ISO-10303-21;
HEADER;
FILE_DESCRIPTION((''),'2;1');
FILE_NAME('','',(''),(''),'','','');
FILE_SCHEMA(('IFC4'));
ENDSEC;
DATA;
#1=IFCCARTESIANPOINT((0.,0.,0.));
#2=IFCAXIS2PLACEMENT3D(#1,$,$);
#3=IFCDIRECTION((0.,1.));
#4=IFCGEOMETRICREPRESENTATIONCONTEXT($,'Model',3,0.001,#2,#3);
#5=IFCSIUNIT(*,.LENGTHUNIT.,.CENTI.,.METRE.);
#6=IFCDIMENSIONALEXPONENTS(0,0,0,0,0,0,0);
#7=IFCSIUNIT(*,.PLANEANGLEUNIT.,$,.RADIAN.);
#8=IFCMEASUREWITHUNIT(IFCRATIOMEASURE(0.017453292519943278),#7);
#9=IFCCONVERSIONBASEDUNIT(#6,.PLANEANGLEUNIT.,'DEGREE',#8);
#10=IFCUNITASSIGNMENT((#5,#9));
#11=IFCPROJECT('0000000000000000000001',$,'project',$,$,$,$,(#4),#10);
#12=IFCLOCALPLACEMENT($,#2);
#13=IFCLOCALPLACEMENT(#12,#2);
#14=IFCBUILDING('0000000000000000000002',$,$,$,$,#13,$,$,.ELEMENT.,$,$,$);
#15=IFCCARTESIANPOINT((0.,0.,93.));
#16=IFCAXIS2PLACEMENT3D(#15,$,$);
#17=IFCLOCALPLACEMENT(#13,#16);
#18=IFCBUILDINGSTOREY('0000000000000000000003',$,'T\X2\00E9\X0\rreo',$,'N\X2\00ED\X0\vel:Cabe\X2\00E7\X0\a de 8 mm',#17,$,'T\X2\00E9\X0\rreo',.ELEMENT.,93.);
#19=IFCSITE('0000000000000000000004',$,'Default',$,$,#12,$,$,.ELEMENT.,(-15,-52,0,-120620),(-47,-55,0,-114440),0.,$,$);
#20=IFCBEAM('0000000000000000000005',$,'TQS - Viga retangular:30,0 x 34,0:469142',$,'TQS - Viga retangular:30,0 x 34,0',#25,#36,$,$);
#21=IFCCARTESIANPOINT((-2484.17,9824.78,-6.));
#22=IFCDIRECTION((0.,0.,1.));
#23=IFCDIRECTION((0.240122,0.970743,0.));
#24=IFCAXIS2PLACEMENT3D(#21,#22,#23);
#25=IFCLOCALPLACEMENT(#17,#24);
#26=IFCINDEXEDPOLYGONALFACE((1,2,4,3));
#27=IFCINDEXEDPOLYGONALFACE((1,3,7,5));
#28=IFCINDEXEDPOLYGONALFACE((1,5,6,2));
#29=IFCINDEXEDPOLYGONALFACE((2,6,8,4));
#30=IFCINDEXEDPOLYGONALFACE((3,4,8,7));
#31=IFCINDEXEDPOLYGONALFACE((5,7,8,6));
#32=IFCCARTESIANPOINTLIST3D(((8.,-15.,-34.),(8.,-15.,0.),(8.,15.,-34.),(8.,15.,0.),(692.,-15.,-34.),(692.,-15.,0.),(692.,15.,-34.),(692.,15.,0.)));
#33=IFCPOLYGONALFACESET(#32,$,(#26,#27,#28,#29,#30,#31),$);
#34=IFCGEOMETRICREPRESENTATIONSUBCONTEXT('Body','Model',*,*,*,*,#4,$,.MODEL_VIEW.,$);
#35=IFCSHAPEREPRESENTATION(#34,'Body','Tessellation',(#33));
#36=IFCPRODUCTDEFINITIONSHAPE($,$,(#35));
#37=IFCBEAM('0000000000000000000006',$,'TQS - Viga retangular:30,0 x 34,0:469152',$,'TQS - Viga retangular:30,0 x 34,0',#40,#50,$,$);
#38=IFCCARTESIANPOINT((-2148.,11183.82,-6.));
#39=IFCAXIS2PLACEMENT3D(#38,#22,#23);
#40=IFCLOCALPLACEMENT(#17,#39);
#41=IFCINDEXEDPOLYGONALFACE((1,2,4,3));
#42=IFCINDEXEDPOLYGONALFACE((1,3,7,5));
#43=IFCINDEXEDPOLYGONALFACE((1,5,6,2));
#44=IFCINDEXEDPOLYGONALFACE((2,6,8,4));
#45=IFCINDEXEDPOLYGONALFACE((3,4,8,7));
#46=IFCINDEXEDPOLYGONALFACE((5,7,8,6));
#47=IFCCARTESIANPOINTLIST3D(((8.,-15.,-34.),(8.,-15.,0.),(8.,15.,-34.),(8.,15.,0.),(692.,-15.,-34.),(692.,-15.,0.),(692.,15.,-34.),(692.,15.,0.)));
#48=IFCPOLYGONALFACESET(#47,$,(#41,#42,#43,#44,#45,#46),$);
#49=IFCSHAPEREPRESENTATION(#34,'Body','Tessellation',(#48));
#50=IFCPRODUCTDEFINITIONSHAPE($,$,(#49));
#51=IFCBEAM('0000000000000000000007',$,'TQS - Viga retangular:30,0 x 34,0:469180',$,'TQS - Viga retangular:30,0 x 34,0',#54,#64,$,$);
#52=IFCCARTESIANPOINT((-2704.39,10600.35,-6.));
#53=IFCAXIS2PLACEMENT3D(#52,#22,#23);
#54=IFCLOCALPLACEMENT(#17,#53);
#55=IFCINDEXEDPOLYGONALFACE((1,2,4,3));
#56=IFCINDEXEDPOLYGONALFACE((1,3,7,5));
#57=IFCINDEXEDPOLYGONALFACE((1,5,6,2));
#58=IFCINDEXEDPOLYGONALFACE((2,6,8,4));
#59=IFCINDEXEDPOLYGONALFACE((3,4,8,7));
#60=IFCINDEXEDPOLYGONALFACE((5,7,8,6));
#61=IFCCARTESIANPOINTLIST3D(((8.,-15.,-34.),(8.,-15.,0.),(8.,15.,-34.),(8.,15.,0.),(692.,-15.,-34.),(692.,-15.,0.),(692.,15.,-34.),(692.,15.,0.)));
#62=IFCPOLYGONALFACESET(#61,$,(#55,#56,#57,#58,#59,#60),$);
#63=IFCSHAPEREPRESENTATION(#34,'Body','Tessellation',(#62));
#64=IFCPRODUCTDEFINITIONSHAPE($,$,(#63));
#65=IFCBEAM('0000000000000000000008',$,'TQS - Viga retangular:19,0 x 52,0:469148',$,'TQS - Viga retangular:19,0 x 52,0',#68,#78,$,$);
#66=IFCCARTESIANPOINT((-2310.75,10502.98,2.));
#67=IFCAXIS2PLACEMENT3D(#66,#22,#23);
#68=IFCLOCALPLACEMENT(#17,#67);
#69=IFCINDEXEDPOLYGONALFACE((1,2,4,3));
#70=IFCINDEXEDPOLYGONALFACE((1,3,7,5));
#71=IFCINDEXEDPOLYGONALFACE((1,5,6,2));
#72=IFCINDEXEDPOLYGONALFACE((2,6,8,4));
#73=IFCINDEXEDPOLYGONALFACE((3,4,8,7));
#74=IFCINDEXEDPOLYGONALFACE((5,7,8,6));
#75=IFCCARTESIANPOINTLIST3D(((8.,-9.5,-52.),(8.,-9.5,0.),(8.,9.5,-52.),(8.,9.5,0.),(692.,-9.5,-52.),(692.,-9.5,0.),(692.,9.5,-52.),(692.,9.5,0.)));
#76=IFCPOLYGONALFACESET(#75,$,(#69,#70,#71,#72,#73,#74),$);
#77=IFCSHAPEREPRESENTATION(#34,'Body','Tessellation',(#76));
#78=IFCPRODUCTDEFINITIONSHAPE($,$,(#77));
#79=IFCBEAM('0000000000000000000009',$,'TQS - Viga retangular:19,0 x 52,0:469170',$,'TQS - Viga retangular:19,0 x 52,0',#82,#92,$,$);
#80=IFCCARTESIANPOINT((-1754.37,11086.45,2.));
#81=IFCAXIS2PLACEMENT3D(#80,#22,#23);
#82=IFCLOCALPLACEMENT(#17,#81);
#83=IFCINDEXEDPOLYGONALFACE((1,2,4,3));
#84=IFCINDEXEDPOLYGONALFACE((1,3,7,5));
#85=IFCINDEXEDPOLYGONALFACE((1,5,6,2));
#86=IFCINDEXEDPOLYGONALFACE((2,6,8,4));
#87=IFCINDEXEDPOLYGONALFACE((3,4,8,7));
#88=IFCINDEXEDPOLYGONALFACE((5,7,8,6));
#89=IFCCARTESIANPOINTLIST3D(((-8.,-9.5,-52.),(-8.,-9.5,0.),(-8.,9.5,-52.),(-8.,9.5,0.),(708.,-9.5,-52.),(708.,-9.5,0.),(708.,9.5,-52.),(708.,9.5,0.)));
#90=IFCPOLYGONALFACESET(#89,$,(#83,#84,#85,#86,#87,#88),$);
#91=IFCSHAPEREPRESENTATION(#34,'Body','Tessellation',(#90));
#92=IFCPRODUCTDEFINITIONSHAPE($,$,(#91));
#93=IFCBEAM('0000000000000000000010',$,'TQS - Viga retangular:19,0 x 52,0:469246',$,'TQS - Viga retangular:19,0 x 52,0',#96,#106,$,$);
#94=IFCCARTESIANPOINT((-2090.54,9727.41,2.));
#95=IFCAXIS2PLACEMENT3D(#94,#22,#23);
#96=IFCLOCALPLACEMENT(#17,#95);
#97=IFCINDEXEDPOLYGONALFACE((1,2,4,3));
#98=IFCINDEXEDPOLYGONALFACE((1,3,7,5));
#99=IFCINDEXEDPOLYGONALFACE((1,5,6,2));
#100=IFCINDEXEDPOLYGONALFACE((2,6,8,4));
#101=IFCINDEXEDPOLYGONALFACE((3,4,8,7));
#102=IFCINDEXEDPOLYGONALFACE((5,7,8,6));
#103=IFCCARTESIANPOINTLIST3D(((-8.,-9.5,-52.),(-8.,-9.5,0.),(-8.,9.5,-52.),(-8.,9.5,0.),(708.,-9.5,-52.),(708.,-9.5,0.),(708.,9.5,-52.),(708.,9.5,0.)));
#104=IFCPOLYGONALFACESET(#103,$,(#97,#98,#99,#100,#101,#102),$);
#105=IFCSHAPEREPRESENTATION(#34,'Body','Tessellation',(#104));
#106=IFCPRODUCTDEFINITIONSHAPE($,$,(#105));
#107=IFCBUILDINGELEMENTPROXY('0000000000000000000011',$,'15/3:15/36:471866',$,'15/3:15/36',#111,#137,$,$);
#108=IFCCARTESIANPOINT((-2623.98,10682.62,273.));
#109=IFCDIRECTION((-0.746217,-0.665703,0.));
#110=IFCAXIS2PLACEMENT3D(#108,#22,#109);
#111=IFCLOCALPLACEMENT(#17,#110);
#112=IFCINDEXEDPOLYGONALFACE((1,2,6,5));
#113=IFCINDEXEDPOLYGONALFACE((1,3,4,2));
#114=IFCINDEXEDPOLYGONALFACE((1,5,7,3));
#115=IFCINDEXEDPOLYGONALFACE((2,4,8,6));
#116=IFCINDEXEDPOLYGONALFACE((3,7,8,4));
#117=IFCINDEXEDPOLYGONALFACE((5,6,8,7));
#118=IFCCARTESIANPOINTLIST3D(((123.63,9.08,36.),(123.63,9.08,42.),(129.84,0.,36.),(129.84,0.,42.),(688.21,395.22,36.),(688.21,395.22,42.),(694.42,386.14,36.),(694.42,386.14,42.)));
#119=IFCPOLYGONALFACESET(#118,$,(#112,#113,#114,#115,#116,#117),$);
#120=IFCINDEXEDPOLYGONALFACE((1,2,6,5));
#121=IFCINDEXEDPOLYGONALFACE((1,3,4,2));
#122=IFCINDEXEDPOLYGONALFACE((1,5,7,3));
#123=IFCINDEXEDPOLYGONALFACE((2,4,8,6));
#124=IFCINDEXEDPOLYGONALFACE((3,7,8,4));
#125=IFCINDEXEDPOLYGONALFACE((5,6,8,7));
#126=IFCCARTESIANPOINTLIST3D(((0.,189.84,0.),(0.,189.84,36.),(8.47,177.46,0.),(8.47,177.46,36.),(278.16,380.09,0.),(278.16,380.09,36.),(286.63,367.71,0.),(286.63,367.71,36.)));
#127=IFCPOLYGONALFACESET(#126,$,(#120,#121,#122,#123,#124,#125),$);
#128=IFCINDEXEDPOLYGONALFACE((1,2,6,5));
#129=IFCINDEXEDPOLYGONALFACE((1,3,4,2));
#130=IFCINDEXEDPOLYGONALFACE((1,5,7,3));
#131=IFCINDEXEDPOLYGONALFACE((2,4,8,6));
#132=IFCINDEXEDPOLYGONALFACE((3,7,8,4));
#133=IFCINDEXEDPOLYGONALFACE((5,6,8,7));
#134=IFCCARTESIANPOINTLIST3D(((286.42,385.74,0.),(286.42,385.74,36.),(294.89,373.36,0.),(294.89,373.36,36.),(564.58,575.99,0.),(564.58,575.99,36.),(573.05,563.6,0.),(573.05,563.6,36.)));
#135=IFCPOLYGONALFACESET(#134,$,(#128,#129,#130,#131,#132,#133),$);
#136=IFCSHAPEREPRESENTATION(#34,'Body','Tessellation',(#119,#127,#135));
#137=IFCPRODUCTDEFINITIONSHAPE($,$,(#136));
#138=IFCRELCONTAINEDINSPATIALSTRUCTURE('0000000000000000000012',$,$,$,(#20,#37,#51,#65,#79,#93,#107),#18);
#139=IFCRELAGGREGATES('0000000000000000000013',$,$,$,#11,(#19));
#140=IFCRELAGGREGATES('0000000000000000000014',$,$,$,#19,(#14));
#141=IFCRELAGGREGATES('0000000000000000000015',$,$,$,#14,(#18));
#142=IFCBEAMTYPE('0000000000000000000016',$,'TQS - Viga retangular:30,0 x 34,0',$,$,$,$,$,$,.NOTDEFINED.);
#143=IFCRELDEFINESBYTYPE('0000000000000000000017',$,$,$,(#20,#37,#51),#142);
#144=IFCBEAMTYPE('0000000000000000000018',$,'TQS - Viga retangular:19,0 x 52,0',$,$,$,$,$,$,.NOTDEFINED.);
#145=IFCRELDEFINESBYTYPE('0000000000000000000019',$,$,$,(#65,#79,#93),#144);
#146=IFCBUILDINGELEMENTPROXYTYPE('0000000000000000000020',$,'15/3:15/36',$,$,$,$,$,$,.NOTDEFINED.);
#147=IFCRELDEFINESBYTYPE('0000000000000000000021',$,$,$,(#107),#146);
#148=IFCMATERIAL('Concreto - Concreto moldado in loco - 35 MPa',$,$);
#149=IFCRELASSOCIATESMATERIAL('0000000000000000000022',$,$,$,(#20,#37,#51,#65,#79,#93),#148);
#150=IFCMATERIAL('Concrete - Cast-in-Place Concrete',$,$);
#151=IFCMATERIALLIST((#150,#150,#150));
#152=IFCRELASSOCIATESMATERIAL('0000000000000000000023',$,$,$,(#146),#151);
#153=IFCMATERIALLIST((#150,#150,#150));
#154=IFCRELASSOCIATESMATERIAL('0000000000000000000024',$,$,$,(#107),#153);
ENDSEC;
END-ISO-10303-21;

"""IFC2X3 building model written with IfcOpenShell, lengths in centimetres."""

from ifc_helpers import new_model, entity, si_unit, converted_unit, direction, frame, frame_2d, origin, place, context, subcontext, project, spatial, rectangle, extrude, source, transform, mapped, material, material_list, type_object, type_shapes, element, save


model = new_model("IFC2X3")

# Units and contexts
model_context = context("Model", 3, precision=0.001, world=origin(), true_north=direction((0.0, 1.0)))
body_context = subcontext(model_context, "Body", "Model", "MODEL_VIEW")
ifc_project = project(units=[si_unit("LENGTHUNIT", "METRE", prefix="CENTI"), converted_unit("PLANEANGLEUNIT", "DEGREE", entity("IfcRatioMeasure", 0.017453292519943278), si_unit("PLANEANGLEUNIT", "RADIAN"), dimensions=[0, 0, 0, 0, 0, 0, 0])], contexts=[model_context])

# Site, building, storey
site_placement = place(None, origin())
site = spatial("IfcSite", under=ifc_project, at=site_placement, Name="Default", CompositionType="ELEMENT", RefLatitude=(-15, -52, 0, -120620), RefLongitude=(-47, -55, 0, -114440), RefElevation=0.0)
building_placement = place(site_placement, origin())
building = spatial("IfcBuilding", under=site, at=building_placement, CompositionType="ELEMENT")
storey_placement = place(building_placement, frame((0.0, 0.0, 93.0)))
storey = spatial("IfcBuildingStorey", under=building, at=storey_placement, Name="Térreo", ObjectType="Nível:Cabeça de 8 mm", LongName="Térreo", CompositionType="ELEMENT", Elevation=93.0)

# Beams
ifc_material_1 = material(Name="Concreto - Concreto moldado in loco - 35 MPa")
beam_type_1 = type_object("IfcBeamType", Name="TQS - Viga retangular:30,0 x 34,0", PredefinedType="NOTDEFINED")
beam_1_placement = place(storey_placement, frame((-2484.17, 9824.78, -6.0), z_axis=(0.0, 0.0, 1.0), x_axis=(0.240122, 0.970743, 0.0)))
element("IfcBeam", 1, at=beam_1_placement, inside=storey, type_object=beam_type_1, material=ifc_material_1, Name="TQS - Viga retangular:30,0 x 34,0:469142", ObjectType="TQS - Viga retangular:30,0 x 34,0", context=body_context, shape_type="SweptSolid", body=[
    extrude(rectangle(XDim=34.0, YDim=30.0, at=frame_2d((0.0, 0.0), x_axis=(1.0, 0.0))), frame((8.0, 0.0, -17.0), z_axis=(1.0, 0.0, 0.0), x_axis=(0.0, 0.0, -1.0)), (0.0, 0.0, 1.0), 684.0),
])
beam_2_placement = place(storey_placement, frame((-2148.0, 11183.82, -6.0), z_axis=(0.0, 0.0, 1.0), x_axis=(0.240122, 0.970743, 0.0)))
element("IfcBeam", 2, at=beam_2_placement, inside=storey, type_object=beam_type_1, material=ifc_material_1, Name="TQS - Viga retangular:30,0 x 34,0:469152", ObjectType="TQS - Viga retangular:30,0 x 34,0", context=body_context, shape_type="SweptSolid", body=[
    extrude(rectangle(XDim=34.0, YDim=30.0, at=frame_2d((0.0, 0.0), x_axis=(1.0, 0.0))), frame((8.0, 0.0, -17.0), z_axis=(1.0, 0.0, 0.0), x_axis=(0.0, 0.0, -1.0)), (0.0, 0.0, 1.0), 684.0),
])
beam_3_placement = place(storey_placement, frame((-2704.39, 10600.35, -6.0), z_axis=(0.0, 0.0, 1.0), x_axis=(0.240122, 0.970743, 0.0)))
element("IfcBeam", 3, at=beam_3_placement, inside=storey, type_object=beam_type_1, material=ifc_material_1, Name="TQS - Viga retangular:30,0 x 34,0:469180", ObjectType="TQS - Viga retangular:30,0 x 34,0", context=body_context, shape_type="SweptSolid", body=[
    extrude(rectangle(XDim=34.0, YDim=30.0, at=frame_2d((0.0, 0.0), x_axis=(1.0, 0.0))), frame((8.0, 0.0, -17.0), z_axis=(1.0, 0.0, 0.0), x_axis=(0.0, 0.0, -1.0)), (0.0, 0.0, 1.0), 684.0),
])
beam_type_2 = type_object("IfcBeamType", Name="TQS - Viga retangular:19,0 x 52,0", PredefinedType="NOTDEFINED")
beam_4_placement = place(storey_placement, frame((-2310.75, 10502.98, 2.0), z_axis=(0.0, 0.0, 1.0), x_axis=(0.240122, 0.970743, 0.0)))
element("IfcBeam", 4, at=beam_4_placement, inside=storey, type_object=beam_type_2, material=ifc_material_1, Name="TQS - Viga retangular:19,0 x 52,0:469148", ObjectType="TQS - Viga retangular:19,0 x 52,0", context=body_context, shape_type="SweptSolid", body=[
    extrude(rectangle(XDim=52.0, YDim=19.0, at=frame_2d((0.0, 0.0), x_axis=(1.0, 0.0))), frame((8.0, 0.0, -26.0), z_axis=(1.0, 0.0, 0.0), x_axis=(0.0, 0.0, -1.0)), (0.0, 0.0, 1.0), 684.0),
])
beam_5_placement = place(storey_placement, frame((-1754.37, 11086.45, 2.0), z_axis=(0.0, 0.0, 1.0), x_axis=(0.240122, 0.970743, 0.0)))
element("IfcBeam", 5, at=beam_5_placement, inside=storey, type_object=beam_type_2, material=ifc_material_1, Name="TQS - Viga retangular:19,0 x 52,0:469170", ObjectType="TQS - Viga retangular:19,0 x 52,0", context=body_context, shape_type="SweptSolid", body=[
    extrude(rectangle(XDim=52.0, YDim=19.0, at=frame_2d((0.0, 0.0), x_axis=(1.0, 0.0))), frame((-8.0, 0.0, -26.0), z_axis=(1.0, 0.0, 0.0), x_axis=(0.0, 0.0, -1.0)), (0.0, 0.0, 1.0), 716.0),
])
beam_6_placement = place(storey_placement, frame((-2090.54, 9727.41, 2.0), z_axis=(0.0, 0.0, 1.0), x_axis=(0.240122, 0.970743, 0.0)))
element("IfcBeam", 6, at=beam_6_placement, inside=storey, type_object=beam_type_2, material=ifc_material_1, Name="TQS - Viga retangular:19,0 x 52,0:469246", ObjectType="TQS - Viga retangular:19,0 x 52,0", context=body_context, shape_type="SweptSolid", body=[
    extrude(rectangle(XDim=52.0, YDim=19.0, at=frame_2d((0.0, 0.0), x_axis=(1.0, 0.0))), frame((-8.0, 0.0, -26.0), z_axis=(1.0, 0.0, 0.0), x_axis=(0.0, 0.0, -1.0)), (0.0, 0.0, 1.0), 716.0),
])

# Building element proxy
ifc_material_2 = material(Name="Concrete - Cast-in-Place Concrete")
ifc_material_list_1 = material_list([ifc_material_2, ifc_material_2, ifc_material_2])
ifc_material_list_2 = material_list([ifc_material_2, ifc_material_2, ifc_material_2])
building_element_proxy_type_1 = type_object("IfcBuildingElementProxyType", Name="15/3:15/36", PredefinedType="NOTDEFINED", material=ifc_material_list_2)
shared_shape_1 = source(origin(), body_context, "Body", "SweptSolid", [
    extrude(rectangle(XDim=11.0, YDim=684.0, at=frame_2d((0.0, 0.0), x_axis=(1.0, 0.0))), frame((409.03, 197.61, 36.0), z_axis=(0.0, 0.0, 1.0), x_axis=(-0.564535, 0.825409, 0.0)), (0.0, 0.0, 1.0), 6.0),
    extrude(rectangle(XDim=337.0, YDim=15.0, at=frame_2d((0.0, 0.0), x_axis=(1.0, 0.0))), frame((143.32, 278.78, 0.0), z_axis=(0.0, 0.0, 1.0), x_axis=(0.825409, 0.564535, 0.0)), (0.0, 0.0, 1.0), 36.0),
    extrude(rectangle(XDim=337.0, YDim=15.0, at=frame_2d((0.0, 0.0), x_axis=(1.0, 0.0))), frame((429.73, 474.67, 0.0), z_axis=(0.0, 0.0, 1.0), x_axis=(0.825409, 0.564535, 0.0)), (0.0, 0.0, 1.0), 36.0),
])
type_shapes(building_element_proxy_type_1, [shared_shape_1])
proxy_1_placement = place(storey_placement, frame((-2623.98, 10682.62, 273.0), z_axis=(0.0, 0.0, 1.0), x_axis=(-0.746217, -0.665703, 0.0)))
element("IfcBuildingElementProxy", 7, at=proxy_1_placement, inside=storey, type_object=building_element_proxy_type_1, material=ifc_material_list_1, Name="15/3:15/36:471866", ObjectType="15/3:15/36", context=body_context, shape_type="MappedRepresentation", body=[
    mapped(shared_shape_1, transform((0.0, 0.0, 0.0), scale=1.0)),
])

save(model, "model.ifc")
